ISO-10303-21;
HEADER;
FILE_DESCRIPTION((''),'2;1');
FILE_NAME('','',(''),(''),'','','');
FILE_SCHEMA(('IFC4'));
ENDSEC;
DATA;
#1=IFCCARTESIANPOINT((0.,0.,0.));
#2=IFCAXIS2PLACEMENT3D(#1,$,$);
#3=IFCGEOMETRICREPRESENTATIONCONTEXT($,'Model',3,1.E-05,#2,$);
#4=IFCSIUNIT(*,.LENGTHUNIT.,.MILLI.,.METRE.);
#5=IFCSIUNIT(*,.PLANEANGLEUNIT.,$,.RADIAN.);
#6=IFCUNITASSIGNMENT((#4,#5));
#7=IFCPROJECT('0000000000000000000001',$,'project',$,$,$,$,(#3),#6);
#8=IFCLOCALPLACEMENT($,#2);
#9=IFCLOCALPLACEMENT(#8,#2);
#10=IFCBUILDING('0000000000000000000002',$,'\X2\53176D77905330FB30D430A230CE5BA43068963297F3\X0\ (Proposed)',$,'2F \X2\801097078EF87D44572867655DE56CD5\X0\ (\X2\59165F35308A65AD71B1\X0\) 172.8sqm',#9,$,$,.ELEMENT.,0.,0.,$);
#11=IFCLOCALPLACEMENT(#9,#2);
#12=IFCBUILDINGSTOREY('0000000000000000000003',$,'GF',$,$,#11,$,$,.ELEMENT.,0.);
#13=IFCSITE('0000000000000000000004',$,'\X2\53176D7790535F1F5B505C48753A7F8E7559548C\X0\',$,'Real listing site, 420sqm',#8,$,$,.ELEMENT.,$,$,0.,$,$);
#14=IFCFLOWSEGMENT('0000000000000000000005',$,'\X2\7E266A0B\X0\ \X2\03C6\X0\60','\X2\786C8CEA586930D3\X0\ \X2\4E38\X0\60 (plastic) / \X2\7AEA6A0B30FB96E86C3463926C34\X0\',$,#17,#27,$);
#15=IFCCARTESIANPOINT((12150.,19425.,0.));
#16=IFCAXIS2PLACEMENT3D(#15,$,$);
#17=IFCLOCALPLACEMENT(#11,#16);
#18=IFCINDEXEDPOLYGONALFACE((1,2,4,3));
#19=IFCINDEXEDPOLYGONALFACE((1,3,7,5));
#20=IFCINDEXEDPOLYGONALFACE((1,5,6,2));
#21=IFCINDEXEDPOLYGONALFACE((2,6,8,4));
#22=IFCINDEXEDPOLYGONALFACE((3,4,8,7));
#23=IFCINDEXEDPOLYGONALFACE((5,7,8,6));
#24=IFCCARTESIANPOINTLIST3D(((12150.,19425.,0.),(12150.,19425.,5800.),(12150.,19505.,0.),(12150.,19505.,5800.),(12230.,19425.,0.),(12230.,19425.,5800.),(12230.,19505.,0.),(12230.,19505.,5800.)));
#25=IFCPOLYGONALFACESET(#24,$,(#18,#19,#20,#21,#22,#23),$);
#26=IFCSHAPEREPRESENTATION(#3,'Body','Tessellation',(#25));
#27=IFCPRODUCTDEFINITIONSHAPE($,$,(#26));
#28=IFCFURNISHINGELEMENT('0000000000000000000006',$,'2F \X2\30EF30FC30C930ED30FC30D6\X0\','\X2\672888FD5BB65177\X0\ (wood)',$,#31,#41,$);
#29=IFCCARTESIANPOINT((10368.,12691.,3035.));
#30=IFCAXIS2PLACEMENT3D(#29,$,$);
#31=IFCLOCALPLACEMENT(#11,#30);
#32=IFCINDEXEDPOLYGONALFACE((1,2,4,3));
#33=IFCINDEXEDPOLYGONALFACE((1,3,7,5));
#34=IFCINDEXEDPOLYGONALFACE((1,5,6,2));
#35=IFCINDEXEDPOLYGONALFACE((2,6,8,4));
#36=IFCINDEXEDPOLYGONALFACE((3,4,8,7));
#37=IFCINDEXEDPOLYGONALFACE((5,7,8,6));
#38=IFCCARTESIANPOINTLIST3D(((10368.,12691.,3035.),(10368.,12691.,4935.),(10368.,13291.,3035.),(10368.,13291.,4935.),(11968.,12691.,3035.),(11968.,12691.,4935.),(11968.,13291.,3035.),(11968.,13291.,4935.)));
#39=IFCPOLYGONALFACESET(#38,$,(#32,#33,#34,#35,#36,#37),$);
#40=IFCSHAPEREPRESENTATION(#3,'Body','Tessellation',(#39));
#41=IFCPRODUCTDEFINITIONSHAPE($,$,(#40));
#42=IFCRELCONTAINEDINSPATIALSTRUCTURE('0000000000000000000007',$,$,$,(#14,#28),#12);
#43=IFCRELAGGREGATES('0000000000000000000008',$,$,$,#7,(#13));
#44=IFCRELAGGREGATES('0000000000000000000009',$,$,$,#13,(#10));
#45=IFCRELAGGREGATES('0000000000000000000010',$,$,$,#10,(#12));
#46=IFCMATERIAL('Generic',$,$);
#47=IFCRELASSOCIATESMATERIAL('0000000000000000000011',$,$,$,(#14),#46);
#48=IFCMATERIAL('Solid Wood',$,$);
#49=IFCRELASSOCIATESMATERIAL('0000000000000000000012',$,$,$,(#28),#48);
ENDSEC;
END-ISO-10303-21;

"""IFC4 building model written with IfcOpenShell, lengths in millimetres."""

from ifc_helpers import new_model, si_unit, frame, frame_2d, origin, place, context, project, spatial, rectangle, extrude, material, element, save


model = new_model("IFC4")

# Units and contexts
model_context = context("Model", 3, precision=1e-05, world=origin())
ifc_project = project(units=[si_unit("LENGTHUNIT", "METRE", prefix="MILLI"), si_unit("PLANEANGLEUNIT", "RADIAN")], contexts=[model_context])

# Site, building, storey
site_placement = place(None, origin())
site = spatial("IfcSite", under=ifc_project, at=site_placement, Name="北海道弟子屈町美留和", ObjectType="Real listing site, 420sqm", CompositionType="ELEMENT", RefElevation=0.0)
building_placement = place(site_placement, origin())
building = spatial("IfcBuilding", under=site, at=building_placement, Name="北海道・ピアノ室と防音 (Proposed)", ObjectType="2F 耐震軸組在来工法 (外張り断熱) 172.8sqm", CompositionType="ELEMENT", ElevationOfRefHeight=0.0, ElevationOfTerrain=0.0)
storey_placement = place(building_placement, origin())
storey = spatial("IfcBuildingStorey", under=building, at=storey_placement, Name="GF", CompositionType="ELEMENT", Elevation=0.0)

# Shared definitions
ifc_material_1 = material(Name="Solid Wood")

# Flow segment
ifc_material_2 = material(Name="Generic")
flow_segment_placement = place(storey_placement, frame((12150.0, 19425.0, 0.0)))
element("IfcFlowSegment", 1, at=flow_segment_placement, inside=storey, material=ifc_material_2, Name="縦樋 φ60", Description="硬質塩ビ 丸60 (plastic) / 竪樋・雨水排水", context=model_context, shape_type="SweptSolid", body=[
    extrude(rectangle(XDim=80.0, YDim=80.0, at=frame_2d((40.0, 40.0))), frame((12150.0, 19425.0, 0.0)), (0.0, 0.0, 1.0), 5800.0),
])

# Furnishing element
furnishing_placement = place(storey_placement, frame((10368.0, 12691.0, 3035.0)))
element("IfcFurnishingElement", 2, at=furnishing_placement, inside=storey, material=ifc_material_1, Name="2F ワードローブ", Description="木製家具 (wood)", context=model_context, shape_type="SweptSolid", body=[
    extrude(rectangle(XDim=1600.0, YDim=600.0, at=frame_2d((800.0, 300.0))), frame((10368.0, 12691.0, 3035.0)), (0.0, 0.0, 1.0), 1900.0),
])

save(model, "model.ifc")
